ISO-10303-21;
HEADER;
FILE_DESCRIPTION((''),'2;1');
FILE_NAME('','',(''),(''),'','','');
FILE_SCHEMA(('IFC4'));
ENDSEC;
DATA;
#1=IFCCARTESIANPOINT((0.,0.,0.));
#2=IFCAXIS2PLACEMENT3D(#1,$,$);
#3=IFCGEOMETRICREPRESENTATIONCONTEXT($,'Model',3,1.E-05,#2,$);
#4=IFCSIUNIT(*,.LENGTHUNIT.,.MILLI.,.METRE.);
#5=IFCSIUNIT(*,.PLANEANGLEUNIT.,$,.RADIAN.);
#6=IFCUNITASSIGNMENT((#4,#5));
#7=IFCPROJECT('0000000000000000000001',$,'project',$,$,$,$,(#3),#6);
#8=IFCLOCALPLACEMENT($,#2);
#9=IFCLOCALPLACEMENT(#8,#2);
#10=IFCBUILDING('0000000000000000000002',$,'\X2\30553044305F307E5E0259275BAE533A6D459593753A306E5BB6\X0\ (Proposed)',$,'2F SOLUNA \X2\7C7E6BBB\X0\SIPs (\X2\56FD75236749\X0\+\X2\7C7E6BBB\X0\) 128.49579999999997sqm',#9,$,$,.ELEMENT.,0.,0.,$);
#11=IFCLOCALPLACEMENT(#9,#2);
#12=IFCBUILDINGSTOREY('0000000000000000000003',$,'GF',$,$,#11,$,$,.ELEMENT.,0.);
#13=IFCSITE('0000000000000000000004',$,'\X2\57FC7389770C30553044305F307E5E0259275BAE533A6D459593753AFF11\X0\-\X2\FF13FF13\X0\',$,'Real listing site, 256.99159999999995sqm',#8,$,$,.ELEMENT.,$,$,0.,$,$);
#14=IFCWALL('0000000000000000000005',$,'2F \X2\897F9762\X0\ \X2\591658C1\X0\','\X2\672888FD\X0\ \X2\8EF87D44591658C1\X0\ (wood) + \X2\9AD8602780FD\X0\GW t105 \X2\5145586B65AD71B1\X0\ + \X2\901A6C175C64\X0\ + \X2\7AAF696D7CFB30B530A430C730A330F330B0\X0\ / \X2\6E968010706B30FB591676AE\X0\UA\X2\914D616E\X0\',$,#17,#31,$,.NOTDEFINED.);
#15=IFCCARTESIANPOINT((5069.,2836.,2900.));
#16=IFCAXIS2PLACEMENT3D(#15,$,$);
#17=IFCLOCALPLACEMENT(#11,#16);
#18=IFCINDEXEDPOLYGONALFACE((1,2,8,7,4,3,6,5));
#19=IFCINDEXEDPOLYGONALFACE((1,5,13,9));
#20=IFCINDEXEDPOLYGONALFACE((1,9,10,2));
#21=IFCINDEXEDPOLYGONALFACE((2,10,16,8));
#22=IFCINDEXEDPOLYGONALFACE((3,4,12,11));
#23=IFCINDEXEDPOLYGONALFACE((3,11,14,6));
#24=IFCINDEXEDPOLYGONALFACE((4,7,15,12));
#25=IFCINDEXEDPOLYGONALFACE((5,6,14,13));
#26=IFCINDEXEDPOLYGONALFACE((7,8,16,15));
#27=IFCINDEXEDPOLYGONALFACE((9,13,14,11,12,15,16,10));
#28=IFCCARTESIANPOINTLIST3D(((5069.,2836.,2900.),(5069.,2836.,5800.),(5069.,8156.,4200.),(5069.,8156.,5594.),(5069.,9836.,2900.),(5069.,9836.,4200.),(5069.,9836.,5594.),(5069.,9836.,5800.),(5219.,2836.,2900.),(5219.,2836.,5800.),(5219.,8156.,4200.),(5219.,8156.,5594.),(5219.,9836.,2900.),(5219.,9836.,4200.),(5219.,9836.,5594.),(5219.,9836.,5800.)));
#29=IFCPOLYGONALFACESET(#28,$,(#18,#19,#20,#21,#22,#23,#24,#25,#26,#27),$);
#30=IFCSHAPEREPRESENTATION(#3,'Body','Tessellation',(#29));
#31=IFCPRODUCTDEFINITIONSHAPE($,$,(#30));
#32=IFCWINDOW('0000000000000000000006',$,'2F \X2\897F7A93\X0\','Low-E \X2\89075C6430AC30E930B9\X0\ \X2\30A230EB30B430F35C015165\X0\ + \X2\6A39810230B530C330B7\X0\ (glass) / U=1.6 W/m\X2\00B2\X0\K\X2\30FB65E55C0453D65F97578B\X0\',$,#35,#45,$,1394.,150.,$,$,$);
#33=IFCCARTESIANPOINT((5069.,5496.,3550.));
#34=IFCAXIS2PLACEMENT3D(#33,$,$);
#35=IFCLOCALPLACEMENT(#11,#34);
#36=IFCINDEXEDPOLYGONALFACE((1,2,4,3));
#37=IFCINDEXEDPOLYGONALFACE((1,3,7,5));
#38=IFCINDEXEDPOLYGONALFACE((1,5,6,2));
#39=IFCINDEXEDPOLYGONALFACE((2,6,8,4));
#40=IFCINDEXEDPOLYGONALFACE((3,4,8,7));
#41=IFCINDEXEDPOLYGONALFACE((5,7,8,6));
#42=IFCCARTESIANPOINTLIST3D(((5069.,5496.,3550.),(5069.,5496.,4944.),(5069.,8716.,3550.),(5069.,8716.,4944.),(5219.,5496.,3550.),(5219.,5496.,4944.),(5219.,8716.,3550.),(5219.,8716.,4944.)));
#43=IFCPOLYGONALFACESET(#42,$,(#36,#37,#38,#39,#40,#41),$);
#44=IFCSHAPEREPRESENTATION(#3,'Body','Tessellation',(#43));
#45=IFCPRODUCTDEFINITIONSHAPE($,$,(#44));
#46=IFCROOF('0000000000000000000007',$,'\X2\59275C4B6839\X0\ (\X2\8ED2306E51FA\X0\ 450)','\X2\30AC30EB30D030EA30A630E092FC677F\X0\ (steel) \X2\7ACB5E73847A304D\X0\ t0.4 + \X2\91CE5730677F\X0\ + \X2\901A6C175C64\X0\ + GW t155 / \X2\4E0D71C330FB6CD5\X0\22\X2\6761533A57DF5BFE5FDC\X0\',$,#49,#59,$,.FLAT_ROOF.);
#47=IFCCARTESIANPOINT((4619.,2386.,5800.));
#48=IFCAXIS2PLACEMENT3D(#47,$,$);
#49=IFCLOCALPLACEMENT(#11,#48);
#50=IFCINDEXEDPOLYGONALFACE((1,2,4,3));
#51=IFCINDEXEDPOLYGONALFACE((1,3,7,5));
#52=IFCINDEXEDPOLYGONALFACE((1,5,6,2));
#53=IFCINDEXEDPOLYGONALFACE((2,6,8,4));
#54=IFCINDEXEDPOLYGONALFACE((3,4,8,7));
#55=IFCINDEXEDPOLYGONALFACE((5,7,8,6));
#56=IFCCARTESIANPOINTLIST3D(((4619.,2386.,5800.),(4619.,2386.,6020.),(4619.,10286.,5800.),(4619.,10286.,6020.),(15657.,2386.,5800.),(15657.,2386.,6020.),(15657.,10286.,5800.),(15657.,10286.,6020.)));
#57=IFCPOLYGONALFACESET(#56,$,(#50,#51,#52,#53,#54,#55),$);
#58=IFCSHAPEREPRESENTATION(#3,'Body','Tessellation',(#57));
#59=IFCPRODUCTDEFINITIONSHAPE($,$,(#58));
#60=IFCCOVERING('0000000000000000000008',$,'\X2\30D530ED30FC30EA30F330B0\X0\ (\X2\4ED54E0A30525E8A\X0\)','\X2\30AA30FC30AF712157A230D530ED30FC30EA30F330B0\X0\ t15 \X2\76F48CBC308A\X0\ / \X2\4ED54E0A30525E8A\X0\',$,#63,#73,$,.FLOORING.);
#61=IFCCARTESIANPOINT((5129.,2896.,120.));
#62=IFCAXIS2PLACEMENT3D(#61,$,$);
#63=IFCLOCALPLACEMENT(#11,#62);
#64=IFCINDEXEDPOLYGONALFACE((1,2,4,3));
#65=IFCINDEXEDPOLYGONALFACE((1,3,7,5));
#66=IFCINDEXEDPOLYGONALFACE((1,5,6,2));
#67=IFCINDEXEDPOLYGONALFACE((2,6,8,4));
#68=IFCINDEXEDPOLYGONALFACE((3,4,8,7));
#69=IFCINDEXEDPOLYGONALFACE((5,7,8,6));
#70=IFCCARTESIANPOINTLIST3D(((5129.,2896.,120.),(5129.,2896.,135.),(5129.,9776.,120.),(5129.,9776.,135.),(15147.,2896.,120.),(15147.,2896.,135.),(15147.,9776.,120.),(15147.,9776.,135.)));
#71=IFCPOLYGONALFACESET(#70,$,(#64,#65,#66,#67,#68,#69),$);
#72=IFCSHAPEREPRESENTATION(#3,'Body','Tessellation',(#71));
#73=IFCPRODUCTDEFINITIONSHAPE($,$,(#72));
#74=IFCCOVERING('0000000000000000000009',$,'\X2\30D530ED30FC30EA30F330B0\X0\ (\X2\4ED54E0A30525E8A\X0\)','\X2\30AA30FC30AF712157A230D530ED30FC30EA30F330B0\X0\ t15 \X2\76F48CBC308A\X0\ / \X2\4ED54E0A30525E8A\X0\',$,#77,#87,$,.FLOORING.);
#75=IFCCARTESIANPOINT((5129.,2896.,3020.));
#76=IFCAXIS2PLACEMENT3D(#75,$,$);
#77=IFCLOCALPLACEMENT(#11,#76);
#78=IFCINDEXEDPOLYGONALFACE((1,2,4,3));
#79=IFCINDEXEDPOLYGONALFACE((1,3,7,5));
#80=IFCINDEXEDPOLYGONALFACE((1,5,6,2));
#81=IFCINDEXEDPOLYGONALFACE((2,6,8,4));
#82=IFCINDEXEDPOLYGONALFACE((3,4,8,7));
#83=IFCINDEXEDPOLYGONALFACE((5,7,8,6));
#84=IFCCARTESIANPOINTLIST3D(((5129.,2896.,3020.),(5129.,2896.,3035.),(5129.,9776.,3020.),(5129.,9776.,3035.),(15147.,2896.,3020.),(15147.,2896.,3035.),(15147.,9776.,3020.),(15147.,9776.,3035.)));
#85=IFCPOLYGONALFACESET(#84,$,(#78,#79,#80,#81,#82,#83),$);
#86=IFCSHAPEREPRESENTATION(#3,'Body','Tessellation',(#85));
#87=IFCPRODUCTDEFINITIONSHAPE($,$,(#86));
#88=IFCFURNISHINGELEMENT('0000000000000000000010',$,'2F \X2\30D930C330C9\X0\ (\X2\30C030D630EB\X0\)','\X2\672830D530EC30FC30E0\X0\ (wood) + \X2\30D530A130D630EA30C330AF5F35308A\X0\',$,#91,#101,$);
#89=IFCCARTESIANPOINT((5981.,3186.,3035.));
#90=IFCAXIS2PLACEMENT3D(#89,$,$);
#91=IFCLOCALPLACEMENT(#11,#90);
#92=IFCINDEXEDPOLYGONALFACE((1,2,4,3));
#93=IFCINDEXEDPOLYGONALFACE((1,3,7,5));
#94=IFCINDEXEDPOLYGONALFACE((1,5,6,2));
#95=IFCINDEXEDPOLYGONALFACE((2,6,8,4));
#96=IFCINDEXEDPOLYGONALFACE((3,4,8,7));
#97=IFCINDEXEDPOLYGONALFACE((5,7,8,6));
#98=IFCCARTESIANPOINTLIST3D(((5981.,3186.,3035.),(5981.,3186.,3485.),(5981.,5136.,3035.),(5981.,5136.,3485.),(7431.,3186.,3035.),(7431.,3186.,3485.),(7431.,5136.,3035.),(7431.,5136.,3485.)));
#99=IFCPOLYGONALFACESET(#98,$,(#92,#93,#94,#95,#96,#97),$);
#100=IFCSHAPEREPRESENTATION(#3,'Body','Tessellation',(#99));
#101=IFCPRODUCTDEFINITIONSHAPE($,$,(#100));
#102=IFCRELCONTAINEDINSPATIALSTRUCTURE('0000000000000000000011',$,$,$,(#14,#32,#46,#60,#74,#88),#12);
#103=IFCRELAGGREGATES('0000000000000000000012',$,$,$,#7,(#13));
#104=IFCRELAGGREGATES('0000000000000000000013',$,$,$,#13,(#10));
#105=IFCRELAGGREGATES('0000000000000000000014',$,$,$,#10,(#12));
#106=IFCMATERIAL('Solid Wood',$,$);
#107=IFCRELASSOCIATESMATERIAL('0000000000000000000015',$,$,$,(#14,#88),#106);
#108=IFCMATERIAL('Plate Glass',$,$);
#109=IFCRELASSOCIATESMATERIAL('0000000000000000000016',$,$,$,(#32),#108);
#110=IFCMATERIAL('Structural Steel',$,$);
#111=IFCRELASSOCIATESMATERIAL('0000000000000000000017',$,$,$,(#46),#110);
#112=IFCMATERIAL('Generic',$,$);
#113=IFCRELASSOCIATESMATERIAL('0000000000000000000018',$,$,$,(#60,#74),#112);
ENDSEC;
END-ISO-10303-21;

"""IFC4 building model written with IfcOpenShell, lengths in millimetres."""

from ifc_helpers import new_model, si_unit, frame, frame_2d, origin, place, context, project, spatial, rectangle, extrude, material, element, fill, save


model = new_model("IFC4")

# Units and contexts
model_context = context("Model", 3, precision=1e-05, world=origin())
ifc_project = project(units=[si_unit("LENGTHUNIT", "METRE", prefix="MILLI"), si_unit("PLANEANGLEUNIT", "RADIAN")], contexts=[model_context])

# Site, building, storey
site_placement = place(None, origin())
site = spatial("IfcSite", under=ifc_project, at=site_placement, Name="埼玉県さいたま市大宮区浅間町１-３３", ObjectType="Real listing site, 256.99159999999995sqm", CompositionType="ELEMENT", RefElevation=0.0)
building_placement = place(site_placement, origin())
building = spatial("IfcBuilding", under=site, at=building_placement, Name="さいたま市大宮区浅間町の家 (Proposed)", ObjectType="2F SOLUNA 籾殻SIPs (国産杉+籾殻) 128.49579999999997sqm", CompositionType="ELEMENT", ElevationOfRefHeight=0.0, ElevationOfTerrain=0.0)
storey_placement = place(building_placement, origin())
storey = spatial("IfcBuildingStorey", under=building, at=storey_placement, Name="GF", CompositionType="ELEMENT", Elevation=0.0)

# Shared definitions
ifc_material_1 = material(Name="Solid Wood")

# Shared definitions
ifc_material_2 = material(Name="Plate Glass")

# Wall, opening, window
wall_1_placement = place(storey_placement, frame((5069.0, 2836.0, 2900.0)))
wall_1 = element("IfcWall", 1, at=wall_1_placement, inside=storey, material=ifc_material_1, Name="2F 西面 外壁", Description="木製 軸組外壁 (wood) + 高性能GW t105 充填断熱 + 通気層 + 窯業系サイディング / 準耐火・外皮UA配慮", PredefinedType="NOTDEFINED", context=model_context, shape_type="SweptSolid", body=[
    extrude(rectangle(XDim=150.0, YDim=7000.0, at=frame_2d((75.0, 3500.0))), frame((5069.0, 2836.0, 2900.0)), (0.0, 0.0, 1.0), 2900.0),
])
opening_1_placement = place(storey_placement, frame((5069.0, 5496.0, 3550.0)))
opening_1 = element("IfcOpeningElement", 2, at=opening_1_placement, cuts=wall_1, PredefinedType="NOTDEFINED", context=model_context, shape_type="SweptSolid", body=[
    extrude(rectangle(XDim=150.0, YDim=3220.0, at=frame_2d((75.0, 1610.0))), frame((5069.0, 5496.0, 3550.0)), (0.0, 0.0, 1.0), 1394.0),
])
window_1_placement = place(storey_placement, frame((5069.0, 5496.0, 3550.0)))
window_1 = element("IfcWindow", 3, at=window_1_placement, inside=storey, material=ifc_material_2, Name="2F 西窓", Description="Low-E 複層ガラス アルゴン封入 + 樹脂サッシ (glass) / U=1.6 W/m²K・日射取得型", OverallHeight=1394.0, OverallWidth=150.0, context=model_context, shape_type="SweptSolid", body=[
    extrude(rectangle(XDim=150.0, YDim=3220.0, at=frame_2d((75.0, 1610.0))), frame((5069.0, 5496.0, 3550.0)), (0.0, 0.0, 1.0), 1394.0),
])
fill(opening_1, window_1)

# Roof
ifc_material_3 = material(Name="Structural Steel")
roof_placement = place(storey_placement, frame((4619.0, 2386.0, 5800.0)))
element("IfcRoof", 4, at=roof_placement, inside=storey, material=ifc_material_3, Name="大屋根 (軒の出 450)", Description="ガルバリウム鋼板 (steel) 立平葺き t0.4 + 野地板 + 通気層 + GW t155 / 不燃・法22条区域対応", PredefinedType="FLAT_ROOF", context=model_context, shape_type="SweptSolid", body=[
    extrude(rectangle(XDim=11038.0, YDim=7900.0, at=frame_2d((5519.0, 3950.0))), frame((4619.0, 2386.0, 5800.0)), (0.0, 0.0, 1.0), 220.0),
])

# Coverings
ifc_material_4 = material(Name="Generic")
covering_1_placement = place(storey_placement, frame((5129.0, 2896.0, 120.0)))
element("IfcCovering", 5, at=covering_1_placement, inside=storey, material=ifc_material_4, Name="フローリング (仕上げ床)", Description="オーク無垢フローリング t15 直貼り / 仕上げ床", PredefinedType="FLOORING", context=model_context, shape_type="SweptSolid", body=[
    extrude(rectangle(XDim=10018.0, YDim=6880.0, at=frame_2d((5009.0, 3440.0))), frame((5129.0, 2896.0, 120.0)), (0.0, 0.0, 1.0), 15.0),
])
covering_2_placement = place(storey_placement, frame((5129.0, 2896.0, 3020.0)))
element("IfcCovering", 6, at=covering_2_placement, inside=storey, material=ifc_material_4, Name="フローリング (仕上げ床)", Description="オーク無垢フローリング t15 直貼り / 仕上げ床", PredefinedType="FLOORING", context=model_context, shape_type="SweptSolid", body=[
    extrude(rectangle(XDim=10018.0, YDim=6880.0, at=frame_2d((5009.0, 3440.0))), frame((5129.0, 2896.0, 3020.0)), (0.0, 0.0, 1.0), 15.0),
])

# Furnishing element
furnishing_placement = place(storey_placement, frame((5981.0, 3186.0, 3035.0)))
element("IfcFurnishingElement", 7, at=furnishing_placement, inside=storey, material=ifc_material_1, Name="2F ベッド (ダブル)", Description="木フレーム (wood) + ファブリック張り", context=model_context, shape_type="SweptSolid", body=[
    extrude(rectangle(XDim=1450.0, YDim=1950.0, at=frame_2d((725.0, 975.0))), frame((5981.0, 3186.0, 3035.0)), (0.0, 0.0, 1.0), 450.0),
])

save(model, "model.ifc")
